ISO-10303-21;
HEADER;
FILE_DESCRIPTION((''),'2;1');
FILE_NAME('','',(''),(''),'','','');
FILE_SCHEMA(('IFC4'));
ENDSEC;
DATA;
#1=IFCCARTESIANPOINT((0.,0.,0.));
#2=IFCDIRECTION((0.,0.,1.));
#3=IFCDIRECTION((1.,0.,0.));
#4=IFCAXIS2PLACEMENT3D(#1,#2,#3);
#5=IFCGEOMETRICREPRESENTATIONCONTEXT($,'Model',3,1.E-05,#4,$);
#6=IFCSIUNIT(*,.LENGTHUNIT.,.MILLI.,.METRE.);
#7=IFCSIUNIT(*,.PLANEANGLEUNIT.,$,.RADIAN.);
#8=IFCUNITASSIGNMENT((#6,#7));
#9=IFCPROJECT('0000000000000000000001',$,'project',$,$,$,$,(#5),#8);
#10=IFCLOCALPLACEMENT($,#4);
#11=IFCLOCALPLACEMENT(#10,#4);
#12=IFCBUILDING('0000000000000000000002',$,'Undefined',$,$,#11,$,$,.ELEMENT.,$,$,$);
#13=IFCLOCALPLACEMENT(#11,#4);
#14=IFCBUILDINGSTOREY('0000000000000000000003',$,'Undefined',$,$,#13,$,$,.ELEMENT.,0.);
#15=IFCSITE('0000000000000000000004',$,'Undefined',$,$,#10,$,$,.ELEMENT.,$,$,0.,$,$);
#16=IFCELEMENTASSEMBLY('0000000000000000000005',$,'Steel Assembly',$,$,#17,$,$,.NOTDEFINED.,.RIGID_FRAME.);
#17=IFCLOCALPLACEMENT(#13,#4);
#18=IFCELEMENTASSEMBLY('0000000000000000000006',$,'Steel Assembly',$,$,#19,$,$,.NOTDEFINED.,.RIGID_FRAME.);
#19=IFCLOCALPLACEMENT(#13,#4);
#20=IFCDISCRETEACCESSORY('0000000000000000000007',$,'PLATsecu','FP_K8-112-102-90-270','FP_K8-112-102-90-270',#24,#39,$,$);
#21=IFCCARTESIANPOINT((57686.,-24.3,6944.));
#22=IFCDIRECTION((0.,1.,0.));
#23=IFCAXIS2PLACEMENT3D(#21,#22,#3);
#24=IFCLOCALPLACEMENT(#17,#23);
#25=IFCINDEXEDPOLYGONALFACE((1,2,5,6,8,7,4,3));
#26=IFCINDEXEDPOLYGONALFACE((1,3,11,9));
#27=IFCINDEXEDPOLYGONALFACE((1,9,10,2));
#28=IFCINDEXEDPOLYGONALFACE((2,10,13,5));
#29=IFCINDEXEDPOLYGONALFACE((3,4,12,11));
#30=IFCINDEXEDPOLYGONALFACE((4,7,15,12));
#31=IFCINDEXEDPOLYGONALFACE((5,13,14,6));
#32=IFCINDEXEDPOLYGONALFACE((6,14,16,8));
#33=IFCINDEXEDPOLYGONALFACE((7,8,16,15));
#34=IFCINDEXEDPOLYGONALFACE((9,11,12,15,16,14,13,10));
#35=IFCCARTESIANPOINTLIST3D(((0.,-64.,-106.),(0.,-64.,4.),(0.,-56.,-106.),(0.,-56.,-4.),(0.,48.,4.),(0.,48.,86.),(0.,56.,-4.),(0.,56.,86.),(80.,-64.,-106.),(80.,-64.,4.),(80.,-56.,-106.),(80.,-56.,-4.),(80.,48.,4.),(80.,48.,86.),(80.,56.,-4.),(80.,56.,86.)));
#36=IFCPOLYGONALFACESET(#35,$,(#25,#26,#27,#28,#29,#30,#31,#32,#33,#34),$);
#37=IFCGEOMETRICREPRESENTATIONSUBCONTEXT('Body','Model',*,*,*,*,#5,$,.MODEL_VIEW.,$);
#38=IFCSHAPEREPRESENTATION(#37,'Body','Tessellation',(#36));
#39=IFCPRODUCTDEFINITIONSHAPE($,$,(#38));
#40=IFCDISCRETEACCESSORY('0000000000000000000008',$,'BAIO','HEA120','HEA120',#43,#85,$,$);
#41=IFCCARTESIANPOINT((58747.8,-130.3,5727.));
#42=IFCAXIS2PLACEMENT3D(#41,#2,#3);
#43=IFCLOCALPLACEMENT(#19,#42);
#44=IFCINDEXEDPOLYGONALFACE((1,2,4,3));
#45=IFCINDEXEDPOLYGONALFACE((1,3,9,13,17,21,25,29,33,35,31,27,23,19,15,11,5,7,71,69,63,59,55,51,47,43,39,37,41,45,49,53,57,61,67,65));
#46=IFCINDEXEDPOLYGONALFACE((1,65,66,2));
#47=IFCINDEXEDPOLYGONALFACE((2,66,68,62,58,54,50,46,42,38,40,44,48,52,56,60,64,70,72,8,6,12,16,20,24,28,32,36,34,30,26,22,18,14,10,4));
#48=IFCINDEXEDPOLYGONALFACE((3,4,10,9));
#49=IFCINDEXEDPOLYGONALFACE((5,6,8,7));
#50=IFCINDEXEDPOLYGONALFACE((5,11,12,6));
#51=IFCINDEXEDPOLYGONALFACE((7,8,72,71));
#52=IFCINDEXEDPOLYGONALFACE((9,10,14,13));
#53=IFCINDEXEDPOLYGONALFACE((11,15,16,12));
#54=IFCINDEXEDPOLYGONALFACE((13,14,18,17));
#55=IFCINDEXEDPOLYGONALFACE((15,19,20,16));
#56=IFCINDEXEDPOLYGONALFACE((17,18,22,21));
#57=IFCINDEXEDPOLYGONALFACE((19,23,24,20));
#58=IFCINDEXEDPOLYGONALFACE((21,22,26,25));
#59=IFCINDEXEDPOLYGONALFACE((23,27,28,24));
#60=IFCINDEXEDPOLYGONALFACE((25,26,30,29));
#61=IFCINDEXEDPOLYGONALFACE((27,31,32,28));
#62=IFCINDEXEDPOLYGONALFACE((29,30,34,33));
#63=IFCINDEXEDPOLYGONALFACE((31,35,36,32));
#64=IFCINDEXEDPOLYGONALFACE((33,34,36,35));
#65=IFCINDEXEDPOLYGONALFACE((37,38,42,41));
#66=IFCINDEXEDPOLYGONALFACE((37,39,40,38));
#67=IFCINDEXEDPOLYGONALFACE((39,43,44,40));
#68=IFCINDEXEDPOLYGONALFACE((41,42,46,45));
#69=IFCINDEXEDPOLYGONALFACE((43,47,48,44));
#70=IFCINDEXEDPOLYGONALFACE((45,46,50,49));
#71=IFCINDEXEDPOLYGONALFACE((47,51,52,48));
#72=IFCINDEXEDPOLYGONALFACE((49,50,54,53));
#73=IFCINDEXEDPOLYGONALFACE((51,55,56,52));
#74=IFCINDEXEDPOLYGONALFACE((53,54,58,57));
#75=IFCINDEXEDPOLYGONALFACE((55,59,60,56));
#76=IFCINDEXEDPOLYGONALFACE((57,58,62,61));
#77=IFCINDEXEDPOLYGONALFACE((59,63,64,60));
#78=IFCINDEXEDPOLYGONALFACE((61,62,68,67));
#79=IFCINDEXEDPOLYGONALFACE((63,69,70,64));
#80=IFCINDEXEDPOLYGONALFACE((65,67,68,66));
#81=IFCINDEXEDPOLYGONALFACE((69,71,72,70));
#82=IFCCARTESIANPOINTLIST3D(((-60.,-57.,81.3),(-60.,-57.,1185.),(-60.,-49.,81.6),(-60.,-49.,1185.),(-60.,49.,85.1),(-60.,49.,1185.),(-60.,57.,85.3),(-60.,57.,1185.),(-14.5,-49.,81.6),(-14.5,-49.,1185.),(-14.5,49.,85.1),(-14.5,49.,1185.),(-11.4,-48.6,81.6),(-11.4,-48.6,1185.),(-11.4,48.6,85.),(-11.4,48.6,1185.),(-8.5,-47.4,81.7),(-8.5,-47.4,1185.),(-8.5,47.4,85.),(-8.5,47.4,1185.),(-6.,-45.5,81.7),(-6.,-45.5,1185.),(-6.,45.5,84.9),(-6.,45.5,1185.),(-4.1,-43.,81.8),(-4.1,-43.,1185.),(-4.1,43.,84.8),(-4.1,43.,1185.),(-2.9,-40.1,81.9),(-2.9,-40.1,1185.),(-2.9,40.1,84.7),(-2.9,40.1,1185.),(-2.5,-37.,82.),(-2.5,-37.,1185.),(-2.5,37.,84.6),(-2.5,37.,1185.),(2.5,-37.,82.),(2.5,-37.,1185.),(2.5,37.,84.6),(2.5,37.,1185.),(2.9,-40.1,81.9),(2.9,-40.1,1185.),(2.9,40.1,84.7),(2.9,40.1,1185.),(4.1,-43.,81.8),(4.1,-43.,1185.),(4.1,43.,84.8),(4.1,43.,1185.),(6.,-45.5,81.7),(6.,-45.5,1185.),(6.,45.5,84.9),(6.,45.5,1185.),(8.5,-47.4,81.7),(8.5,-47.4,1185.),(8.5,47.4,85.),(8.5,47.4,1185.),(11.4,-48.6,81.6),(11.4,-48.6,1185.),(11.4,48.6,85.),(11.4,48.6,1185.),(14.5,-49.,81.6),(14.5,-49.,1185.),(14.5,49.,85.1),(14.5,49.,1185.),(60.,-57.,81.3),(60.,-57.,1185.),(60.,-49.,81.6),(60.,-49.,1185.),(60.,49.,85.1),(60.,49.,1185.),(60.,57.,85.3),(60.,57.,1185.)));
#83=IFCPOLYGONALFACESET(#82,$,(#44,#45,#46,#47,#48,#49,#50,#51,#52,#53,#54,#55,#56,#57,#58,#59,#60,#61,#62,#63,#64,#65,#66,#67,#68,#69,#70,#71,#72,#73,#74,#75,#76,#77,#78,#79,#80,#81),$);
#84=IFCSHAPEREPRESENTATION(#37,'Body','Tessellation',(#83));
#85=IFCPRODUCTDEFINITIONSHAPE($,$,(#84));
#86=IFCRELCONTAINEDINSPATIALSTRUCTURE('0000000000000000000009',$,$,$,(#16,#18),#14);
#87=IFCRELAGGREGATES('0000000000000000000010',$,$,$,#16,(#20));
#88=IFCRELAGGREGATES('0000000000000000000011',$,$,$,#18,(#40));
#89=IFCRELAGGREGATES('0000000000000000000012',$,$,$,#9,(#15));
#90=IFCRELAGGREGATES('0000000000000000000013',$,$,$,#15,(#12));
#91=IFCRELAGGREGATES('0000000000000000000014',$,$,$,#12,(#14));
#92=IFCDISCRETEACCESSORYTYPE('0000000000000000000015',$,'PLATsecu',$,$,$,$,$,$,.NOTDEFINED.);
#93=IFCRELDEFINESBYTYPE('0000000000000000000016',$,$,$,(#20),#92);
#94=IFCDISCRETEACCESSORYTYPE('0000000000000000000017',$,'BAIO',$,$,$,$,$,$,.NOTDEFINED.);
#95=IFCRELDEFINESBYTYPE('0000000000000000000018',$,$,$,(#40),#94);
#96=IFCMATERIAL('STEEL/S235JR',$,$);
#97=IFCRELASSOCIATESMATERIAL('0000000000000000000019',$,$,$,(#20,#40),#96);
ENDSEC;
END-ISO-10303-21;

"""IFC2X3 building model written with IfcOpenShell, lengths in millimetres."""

from ifc_helpers import new_model, si_unit, frame, origin_with_axes, origin_2d_with_axis, place, context, subcontext, project, spatial, polyline, i_section, outline, extrude, clip, halfspace, material, type_object, element, aggregate, save


model = new_model("IFC2X3")

# Units and contexts
model_context = context("Model", 3, precision=1e-05, world=origin_with_axes())
body_context = subcontext(model_context, "Body", "Model", "MODEL_VIEW")
ifc_project = project(units=[si_unit("LENGTHUNIT", "METRE", prefix="MILLI"), si_unit("PLANEANGLEUNIT", "RADIAN")], contexts=[model_context])

# Site, building, storey
site_placement = place(None, origin_with_axes())
site = spatial("IfcSite", under=ifc_project, at=site_placement, Name="Undefined", CompositionType="ELEMENT", RefElevation=0.0)
building_placement = place(site_placement, origin_with_axes())
building = spatial("IfcBuilding", under=site, at=building_placement, Name="Undefined", CompositionType="ELEMENT")
storey_placement = place(building_placement, origin_with_axes())
storey = spatial("IfcBuildingStorey", under=building, at=storey_placement, Name="Undefined", CompositionType="ELEMENT", Elevation=0.0)

# Element assembly
ifc_material_1 = material(Name="STEEL/S235JR")
assembly_1_placement = place(storey_placement, origin_with_axes())
assembly_1 = element("IfcElementAssembly", 1, at=assembly_1_placement, inside=storey, Name="Steel Assembly", AssemblyPlace="NOTDEFINED", PredefinedType="RIGID_FRAME")

# Element assembly
assembly_2_placement = place(storey_placement, origin_with_axes())
assembly_2 = element("IfcElementAssembly", 2, at=assembly_2_placement, inside=storey, Name="Steel Assembly", AssemblyPlace="NOTDEFINED", PredefinedType="RIGID_FRAME")

# Discrete accessory
discrete_accessory_type_1 = type_object("IfcDiscreteAccessoryType", Name="PLATsecu")
discrete_accessory_1_placement = place(assembly_1_placement, frame((57686.0, -24.3, 6944.0), z_axis=(0.0, 1.0, 0.0), x_axis=(1.0, 0.0, 0.0)))
discrete_accessory_1 = element("IfcDiscreteAccessory", 3, at=discrete_accessory_1_placement, type_object=discrete_accessory_type_1, material=ifc_material_1, Name="PLATsecu", Description="FP_K8-112-102-90-270", ObjectType="FP_K8-112-102-90-270", context=body_context, shape_type="SweptSolid", body=[
    extrude(outline(polyline([(-56.0, 86.0), (-48.0, 86.0), (-48.0, 4.0), (64.0, 4.0), (64.0, -106.0), (56.0, -106.0), (56.0, -4.0), (-56.0, -4.0), (-56.0, 86.0)])), frame((80.0, 0.0, 0.0), z_axis=(-1.0, 0.0, 0.0), x_axis=(0.0, -1.0, 0.0)), (0.0, 0.0, 1.0), 80.0),
])
aggregate(assembly_1, [discrete_accessory_1])

# Discrete accessory
discrete_accessory_type_2 = type_object("IfcDiscreteAccessoryType", Name="BAIO")
discrete_accessory_2_placement = place(assembly_2_placement, frame((58747.8, -130.3, 5727.0), z_axis=(0.0, 0.0, 1.0), x_axis=(1.0, 0.0, 0.0)))
discrete_accessory_2 = element("IfcDiscreteAccessory", 4, at=discrete_accessory_2_placement, type_object=discrete_accessory_type_2, material=ifc_material_1, Name="BAIO", Description="HEA120", ObjectType="HEA120", context=body_context, shape_type="Clipping", body=[
    clip(clip(extrude(i_section(OverallWidth=120.0, OverallDepth=114.0, WebThickness=5.0, FlangeThickness=8.0, FilletRadius=12.0, at=origin_2d_with_axis()), frame((0.0, 0.0, 1185.0), z_axis=(0.0, 0.0, -1.0), x_axis=(1.0, 0.0, 0.0)), (0.0, 0.0, 1.0), 1185.0), halfspace(frame((-60.0, 57.0, 85.3), z_axis=(0.0, 0.034946, -0.999389), x_axis=(0.0, -0.999389, -0.034946)), False)), halfspace(frame((0.0, -57.0, 1185.0), z_axis=(0.0, 0.0, 1.0), x_axis=(-1.0, 0.0, 0.0)), False)),
])
aggregate(assembly_2, [discrete_accessory_2])

save(model, "model.ifc")
